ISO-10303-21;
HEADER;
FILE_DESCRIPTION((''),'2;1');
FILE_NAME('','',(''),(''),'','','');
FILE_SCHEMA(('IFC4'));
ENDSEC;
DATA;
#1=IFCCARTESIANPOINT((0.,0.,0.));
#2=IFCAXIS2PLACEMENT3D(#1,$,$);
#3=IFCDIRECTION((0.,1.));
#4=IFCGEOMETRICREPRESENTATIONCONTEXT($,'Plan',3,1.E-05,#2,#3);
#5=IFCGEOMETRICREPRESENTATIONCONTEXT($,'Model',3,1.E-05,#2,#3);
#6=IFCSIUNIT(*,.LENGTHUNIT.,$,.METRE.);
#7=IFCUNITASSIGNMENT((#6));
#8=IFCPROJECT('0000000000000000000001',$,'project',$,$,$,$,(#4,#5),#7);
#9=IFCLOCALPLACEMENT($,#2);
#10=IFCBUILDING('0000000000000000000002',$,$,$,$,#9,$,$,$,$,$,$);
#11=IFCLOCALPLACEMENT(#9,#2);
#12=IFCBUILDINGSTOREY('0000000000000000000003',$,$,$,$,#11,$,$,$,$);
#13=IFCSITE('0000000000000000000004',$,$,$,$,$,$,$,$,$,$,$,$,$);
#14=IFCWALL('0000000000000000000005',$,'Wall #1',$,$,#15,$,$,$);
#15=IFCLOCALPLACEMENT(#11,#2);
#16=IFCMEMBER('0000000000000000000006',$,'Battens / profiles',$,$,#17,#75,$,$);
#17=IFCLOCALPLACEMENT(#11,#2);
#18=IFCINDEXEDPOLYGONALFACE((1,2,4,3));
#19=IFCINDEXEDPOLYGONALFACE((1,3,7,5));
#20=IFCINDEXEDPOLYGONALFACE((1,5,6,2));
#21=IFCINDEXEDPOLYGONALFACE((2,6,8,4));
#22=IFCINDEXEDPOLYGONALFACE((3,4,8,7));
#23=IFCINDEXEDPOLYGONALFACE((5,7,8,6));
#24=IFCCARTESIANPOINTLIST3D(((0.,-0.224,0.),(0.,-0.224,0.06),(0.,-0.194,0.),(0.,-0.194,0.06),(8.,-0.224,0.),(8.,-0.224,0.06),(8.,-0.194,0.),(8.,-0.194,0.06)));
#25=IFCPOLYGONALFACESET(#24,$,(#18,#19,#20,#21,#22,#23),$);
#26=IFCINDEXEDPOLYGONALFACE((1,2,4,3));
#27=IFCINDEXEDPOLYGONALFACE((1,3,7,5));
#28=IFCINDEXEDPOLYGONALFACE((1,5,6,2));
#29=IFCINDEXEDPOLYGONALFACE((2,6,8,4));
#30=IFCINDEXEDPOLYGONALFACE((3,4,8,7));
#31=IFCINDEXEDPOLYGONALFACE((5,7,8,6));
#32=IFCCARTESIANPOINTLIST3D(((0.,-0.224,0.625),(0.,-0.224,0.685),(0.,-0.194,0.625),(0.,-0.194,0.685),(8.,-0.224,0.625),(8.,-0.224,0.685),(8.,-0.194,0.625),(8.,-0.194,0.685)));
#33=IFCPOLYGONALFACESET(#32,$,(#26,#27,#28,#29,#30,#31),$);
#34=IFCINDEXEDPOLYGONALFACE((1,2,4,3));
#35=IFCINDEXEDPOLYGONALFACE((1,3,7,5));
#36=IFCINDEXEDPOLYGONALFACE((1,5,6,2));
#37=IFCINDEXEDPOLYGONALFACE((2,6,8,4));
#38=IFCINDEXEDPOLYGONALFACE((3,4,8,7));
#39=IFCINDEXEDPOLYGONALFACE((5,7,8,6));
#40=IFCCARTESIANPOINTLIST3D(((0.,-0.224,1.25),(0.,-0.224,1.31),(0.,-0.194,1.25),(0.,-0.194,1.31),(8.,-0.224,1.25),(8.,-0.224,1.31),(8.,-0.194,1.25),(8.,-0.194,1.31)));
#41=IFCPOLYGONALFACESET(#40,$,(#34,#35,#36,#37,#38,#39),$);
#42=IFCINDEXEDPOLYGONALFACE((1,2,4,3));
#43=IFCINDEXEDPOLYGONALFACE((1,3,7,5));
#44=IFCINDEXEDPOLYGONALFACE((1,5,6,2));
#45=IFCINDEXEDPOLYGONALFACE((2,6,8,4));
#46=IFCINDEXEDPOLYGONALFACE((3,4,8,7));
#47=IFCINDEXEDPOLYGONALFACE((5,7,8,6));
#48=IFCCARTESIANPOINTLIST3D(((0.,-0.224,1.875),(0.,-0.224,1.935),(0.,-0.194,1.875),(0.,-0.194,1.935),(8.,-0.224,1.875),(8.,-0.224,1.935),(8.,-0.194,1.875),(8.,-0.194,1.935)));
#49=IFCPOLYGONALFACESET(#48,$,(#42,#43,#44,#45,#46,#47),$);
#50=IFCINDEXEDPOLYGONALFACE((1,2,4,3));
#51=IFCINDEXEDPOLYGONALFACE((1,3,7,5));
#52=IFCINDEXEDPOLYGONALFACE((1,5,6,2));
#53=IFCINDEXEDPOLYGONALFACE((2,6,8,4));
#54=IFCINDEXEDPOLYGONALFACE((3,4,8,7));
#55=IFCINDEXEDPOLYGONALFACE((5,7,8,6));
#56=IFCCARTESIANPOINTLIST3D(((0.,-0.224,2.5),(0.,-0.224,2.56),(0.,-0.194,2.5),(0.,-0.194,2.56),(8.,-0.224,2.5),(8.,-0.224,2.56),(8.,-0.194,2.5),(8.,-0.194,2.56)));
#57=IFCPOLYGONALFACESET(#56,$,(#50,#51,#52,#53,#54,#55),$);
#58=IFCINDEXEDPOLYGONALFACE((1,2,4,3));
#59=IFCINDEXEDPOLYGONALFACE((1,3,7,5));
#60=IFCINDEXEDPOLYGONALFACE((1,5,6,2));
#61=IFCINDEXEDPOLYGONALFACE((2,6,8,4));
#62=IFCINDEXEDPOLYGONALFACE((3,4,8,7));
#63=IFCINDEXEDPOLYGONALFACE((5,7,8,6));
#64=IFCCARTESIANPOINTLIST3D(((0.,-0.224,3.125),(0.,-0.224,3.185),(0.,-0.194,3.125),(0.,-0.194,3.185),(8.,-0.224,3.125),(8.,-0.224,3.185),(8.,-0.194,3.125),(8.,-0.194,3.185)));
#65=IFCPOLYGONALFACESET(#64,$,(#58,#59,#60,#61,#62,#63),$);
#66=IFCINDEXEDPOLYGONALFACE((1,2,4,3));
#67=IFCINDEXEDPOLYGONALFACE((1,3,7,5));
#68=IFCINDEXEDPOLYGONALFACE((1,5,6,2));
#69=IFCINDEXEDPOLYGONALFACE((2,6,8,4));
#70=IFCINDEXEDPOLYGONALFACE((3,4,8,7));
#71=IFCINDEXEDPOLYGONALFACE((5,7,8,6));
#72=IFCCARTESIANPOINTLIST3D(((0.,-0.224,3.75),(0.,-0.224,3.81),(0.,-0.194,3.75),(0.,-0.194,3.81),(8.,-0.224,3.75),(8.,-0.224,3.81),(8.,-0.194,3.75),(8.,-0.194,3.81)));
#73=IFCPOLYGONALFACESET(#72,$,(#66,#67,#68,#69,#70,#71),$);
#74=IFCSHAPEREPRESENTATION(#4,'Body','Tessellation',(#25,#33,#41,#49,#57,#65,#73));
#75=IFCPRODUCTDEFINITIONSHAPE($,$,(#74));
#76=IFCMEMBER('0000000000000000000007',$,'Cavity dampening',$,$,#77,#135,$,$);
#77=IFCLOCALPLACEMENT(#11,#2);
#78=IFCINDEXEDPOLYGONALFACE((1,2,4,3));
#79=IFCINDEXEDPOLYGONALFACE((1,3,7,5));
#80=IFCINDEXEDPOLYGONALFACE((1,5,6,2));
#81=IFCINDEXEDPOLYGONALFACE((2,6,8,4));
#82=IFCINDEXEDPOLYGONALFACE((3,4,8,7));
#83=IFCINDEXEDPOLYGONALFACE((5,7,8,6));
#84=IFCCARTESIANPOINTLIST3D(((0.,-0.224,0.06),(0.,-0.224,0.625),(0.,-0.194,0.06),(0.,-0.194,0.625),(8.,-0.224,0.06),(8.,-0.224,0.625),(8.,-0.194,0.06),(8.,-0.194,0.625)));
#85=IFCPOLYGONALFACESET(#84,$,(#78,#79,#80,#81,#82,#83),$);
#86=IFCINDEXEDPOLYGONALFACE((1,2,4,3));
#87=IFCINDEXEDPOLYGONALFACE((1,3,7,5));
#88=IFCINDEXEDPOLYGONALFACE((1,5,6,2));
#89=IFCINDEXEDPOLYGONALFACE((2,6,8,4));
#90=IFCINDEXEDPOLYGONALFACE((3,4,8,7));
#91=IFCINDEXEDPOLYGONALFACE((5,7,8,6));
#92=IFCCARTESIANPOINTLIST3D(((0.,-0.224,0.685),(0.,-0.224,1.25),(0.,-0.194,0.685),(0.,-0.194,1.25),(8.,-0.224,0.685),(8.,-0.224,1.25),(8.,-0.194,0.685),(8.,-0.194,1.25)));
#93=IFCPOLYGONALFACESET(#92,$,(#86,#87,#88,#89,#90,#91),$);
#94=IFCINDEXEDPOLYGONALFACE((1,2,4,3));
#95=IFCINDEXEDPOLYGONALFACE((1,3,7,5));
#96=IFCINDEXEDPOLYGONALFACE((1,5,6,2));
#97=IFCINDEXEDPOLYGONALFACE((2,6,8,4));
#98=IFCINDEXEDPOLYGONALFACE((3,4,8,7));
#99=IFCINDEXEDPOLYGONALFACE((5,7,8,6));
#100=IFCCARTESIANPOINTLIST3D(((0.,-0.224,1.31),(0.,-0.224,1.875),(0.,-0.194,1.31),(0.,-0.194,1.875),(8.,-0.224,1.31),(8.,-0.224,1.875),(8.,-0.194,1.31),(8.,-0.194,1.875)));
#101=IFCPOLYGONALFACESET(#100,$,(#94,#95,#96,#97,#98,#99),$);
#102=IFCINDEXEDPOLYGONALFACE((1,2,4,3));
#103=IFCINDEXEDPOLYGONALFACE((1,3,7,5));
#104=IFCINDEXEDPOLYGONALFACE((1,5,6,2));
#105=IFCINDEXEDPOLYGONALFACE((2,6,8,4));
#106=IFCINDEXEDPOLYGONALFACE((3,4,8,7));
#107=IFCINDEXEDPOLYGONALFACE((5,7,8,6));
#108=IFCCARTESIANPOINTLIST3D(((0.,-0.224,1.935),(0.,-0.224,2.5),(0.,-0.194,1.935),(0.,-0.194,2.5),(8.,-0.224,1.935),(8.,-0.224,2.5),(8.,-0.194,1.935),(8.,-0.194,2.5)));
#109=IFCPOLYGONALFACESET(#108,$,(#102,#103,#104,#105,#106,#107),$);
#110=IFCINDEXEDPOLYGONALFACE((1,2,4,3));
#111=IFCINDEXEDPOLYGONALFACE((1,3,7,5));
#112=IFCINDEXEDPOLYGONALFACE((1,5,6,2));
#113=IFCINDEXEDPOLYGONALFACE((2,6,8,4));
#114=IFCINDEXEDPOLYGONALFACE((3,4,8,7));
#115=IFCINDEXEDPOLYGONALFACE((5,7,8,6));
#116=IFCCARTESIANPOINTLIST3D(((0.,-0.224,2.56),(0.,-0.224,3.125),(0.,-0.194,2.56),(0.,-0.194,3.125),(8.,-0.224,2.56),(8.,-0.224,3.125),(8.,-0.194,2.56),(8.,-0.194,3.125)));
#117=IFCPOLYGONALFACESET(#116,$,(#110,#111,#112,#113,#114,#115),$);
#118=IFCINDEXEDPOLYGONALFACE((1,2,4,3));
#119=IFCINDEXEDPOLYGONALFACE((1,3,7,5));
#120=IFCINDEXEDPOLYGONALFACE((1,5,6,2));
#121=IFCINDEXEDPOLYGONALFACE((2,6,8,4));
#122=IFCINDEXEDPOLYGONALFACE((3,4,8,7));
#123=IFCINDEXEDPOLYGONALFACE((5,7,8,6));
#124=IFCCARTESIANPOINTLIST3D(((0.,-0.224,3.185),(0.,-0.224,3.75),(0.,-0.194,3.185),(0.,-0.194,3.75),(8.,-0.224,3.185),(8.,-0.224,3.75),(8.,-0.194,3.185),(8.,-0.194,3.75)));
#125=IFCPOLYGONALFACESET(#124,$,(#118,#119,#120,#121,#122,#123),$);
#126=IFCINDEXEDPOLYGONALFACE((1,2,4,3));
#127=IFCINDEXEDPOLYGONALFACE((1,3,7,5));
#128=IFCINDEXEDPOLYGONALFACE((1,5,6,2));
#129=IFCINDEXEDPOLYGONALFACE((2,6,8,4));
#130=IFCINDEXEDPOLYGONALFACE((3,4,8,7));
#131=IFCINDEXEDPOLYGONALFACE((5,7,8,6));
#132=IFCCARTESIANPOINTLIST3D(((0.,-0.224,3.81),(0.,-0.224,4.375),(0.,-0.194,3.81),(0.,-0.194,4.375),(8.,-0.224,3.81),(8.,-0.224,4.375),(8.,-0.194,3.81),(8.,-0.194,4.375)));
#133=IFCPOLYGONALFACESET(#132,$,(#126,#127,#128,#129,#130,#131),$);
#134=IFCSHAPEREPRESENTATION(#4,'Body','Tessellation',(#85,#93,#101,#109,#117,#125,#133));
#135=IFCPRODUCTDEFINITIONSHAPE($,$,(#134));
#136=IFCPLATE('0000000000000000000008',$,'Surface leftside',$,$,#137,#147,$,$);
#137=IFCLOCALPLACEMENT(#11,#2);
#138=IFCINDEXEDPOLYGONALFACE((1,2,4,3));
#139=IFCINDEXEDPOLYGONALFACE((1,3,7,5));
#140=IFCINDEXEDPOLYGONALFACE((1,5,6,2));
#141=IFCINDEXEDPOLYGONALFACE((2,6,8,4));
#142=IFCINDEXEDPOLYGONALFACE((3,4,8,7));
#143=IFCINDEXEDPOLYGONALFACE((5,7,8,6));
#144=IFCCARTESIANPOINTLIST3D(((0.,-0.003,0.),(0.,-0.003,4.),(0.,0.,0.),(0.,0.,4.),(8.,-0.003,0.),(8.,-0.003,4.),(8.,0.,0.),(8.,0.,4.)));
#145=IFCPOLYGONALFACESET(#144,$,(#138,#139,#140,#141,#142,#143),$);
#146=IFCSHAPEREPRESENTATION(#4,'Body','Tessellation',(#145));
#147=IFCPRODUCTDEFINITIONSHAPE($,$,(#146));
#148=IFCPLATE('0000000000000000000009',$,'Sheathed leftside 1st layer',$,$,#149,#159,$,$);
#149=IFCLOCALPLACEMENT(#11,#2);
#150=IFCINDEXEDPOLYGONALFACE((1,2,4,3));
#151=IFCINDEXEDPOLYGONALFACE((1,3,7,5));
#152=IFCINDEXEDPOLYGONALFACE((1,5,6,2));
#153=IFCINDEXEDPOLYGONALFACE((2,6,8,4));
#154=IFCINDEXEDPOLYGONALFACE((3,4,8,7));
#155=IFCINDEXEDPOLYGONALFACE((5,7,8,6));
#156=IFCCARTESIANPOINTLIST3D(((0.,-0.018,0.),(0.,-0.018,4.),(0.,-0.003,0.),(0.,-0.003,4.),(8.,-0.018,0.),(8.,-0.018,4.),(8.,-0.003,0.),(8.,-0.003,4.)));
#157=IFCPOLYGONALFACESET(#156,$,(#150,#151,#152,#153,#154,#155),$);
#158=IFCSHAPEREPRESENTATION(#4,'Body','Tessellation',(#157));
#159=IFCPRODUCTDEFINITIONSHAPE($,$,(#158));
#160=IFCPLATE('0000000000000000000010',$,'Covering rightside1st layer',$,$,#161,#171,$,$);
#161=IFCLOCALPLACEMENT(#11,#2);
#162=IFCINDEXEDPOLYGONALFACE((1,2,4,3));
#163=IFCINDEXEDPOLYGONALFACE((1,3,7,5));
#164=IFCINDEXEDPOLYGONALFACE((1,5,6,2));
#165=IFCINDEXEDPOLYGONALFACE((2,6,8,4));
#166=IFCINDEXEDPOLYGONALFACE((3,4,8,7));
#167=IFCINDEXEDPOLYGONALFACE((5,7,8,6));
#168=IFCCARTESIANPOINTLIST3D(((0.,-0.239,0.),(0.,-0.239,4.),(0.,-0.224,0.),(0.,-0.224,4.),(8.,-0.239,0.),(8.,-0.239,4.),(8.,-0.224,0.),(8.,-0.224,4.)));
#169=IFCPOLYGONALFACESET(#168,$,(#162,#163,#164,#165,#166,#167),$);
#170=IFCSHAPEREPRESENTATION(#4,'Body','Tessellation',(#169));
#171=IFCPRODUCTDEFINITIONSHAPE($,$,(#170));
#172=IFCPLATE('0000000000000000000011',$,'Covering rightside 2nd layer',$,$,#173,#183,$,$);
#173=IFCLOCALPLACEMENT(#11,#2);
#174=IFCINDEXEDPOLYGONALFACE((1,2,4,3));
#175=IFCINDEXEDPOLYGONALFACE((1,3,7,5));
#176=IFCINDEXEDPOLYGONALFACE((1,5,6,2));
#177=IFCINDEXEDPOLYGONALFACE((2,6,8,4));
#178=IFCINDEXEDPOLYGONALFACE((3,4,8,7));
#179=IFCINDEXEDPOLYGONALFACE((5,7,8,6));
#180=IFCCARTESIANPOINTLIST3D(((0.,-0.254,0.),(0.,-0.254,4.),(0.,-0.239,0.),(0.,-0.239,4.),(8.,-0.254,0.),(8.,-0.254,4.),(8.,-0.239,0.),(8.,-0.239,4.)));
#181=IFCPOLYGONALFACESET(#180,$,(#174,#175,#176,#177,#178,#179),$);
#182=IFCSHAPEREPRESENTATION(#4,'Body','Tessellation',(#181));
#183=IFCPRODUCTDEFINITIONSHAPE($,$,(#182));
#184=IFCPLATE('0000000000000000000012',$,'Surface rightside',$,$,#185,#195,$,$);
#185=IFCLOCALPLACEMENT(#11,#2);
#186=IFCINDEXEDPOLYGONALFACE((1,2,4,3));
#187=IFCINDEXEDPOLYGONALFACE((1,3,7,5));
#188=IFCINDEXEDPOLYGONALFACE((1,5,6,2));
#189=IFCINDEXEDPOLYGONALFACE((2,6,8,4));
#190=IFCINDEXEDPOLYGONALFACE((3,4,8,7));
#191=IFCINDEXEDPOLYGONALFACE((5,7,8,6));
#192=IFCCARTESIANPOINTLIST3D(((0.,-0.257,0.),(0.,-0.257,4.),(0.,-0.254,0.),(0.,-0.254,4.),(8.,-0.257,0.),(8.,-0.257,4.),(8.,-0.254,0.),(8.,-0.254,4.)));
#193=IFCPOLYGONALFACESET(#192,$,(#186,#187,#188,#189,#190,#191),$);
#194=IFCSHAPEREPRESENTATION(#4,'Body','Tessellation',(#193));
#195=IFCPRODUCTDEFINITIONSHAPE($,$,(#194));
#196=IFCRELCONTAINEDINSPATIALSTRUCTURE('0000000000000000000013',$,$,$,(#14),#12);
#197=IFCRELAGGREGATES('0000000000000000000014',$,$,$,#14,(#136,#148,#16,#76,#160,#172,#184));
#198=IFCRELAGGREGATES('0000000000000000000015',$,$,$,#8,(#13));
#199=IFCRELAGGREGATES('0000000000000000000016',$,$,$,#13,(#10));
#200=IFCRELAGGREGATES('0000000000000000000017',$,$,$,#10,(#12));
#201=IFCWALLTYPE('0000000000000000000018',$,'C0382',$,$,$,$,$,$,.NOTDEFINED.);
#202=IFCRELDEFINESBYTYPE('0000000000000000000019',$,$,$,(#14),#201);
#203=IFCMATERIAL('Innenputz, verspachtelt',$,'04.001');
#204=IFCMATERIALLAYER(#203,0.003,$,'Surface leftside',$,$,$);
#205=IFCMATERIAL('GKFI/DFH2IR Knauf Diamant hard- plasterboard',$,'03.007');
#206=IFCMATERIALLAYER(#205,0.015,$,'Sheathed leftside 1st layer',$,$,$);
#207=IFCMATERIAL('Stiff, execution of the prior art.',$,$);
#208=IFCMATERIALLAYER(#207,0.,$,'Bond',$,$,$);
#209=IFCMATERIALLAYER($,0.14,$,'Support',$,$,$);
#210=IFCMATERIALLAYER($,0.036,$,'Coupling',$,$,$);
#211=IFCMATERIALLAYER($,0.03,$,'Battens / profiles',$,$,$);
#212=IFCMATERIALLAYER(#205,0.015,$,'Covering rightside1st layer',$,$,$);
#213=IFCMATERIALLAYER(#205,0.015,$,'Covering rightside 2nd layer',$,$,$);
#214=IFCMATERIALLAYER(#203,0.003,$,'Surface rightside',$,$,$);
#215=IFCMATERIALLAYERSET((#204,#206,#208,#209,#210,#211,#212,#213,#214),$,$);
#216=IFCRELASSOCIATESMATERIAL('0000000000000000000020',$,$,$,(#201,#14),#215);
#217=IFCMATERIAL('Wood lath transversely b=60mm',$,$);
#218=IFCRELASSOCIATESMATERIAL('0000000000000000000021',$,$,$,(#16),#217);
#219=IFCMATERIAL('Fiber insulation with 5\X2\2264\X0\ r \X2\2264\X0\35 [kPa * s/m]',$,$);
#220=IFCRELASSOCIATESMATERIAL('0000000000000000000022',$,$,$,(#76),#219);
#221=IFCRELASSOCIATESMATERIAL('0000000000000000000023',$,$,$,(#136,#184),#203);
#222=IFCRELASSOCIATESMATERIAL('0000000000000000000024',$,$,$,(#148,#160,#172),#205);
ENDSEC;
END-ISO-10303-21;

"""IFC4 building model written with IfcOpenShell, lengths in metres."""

from ifc_helpers import new_model, si_unit, direction, frame, frame_2d, origin, origin_with_axes, place, context, project, spatial, rectangle, extrude, material, layer, layer_set, type_object, element, aggregate, save


model = new_model("IFC4")

# Units and contexts
plan_context = context("Plan", 3, precision=1e-05, world=origin(), true_north=direction((0.0, 1.0)))
model_context = context("Model", 3, precision=1e-05, world=origin(), true_north=direction((0.0, 1.0)))
ifc_project = project(units=[si_unit("LENGTHUNIT", "METRE")], contexts=[plan_context, model_context])

# Site, building, storey
site = spatial("IfcSite", under=ifc_project)
building_placement = place(None, origin())
building = spatial("IfcBuilding", under=site, at=building_placement)
storey_placement = place(building_placement, origin())
storey = spatial("IfcBuildingStorey", under=building, at=storey_placement)

# Wall, members, plates
ifc_material_1 = material(Name="Innenputz, verspachtelt", Category="04.001")
ifc_layer_1 = layer(ifc_material_1, 0.003, Name="Surface leftside")
ifc_material_2 = material(Name="GKFI/DFH2IR Knauf Diamant hard- plasterboard", Category="03.007")
ifc_layer_2 = layer(ifc_material_2, 0.015, Name="Sheathed leftside 1st layer")
ifc_material_3 = material(Name="Stiff, execution of the prior art.")
ifc_layer_3 = layer(ifc_material_3, 0.0, Name="Bond")
ifc_layer_4 = layer(None, 0.14, Name="Support")
ifc_layer_5 = layer(None, 0.036, Name="Coupling")
ifc_layer_6 = layer(None, 0.03, Name="Battens / profiles")
ifc_layer_7 = layer(ifc_material_2, 0.015, Name="Covering rightside1st layer")
ifc_layer_8 = layer(ifc_material_2, 0.015, Name="Covering rightside 2nd layer")
ifc_layer_9 = layer(ifc_material_1, 0.003, Name="Surface rightside")
ifc_layer_set = layer_set([ifc_layer_1, ifc_layer_2, ifc_layer_3, ifc_layer_4, ifc_layer_5, ifc_layer_6, ifc_layer_7, ifc_layer_8, ifc_layer_9])
wall_type = type_object("IfcWallType", Name="C0382", PredefinedType="NOTDEFINED", material=ifc_layer_set)
wall_placement = place(None, frame((0.0, 0.0, 0.0), z_axis=(0.0, -1.0, 0.0), x_axis=(1.0, 0.0, 0.0)))
wall = element("IfcWall", 1, at=wall_placement, inside=storey, type_object=wall_type, material=ifc_layer_set, Name="Wall #1")
ifc_material_4 = material(Name="Wood lath transversely b=60mm")
member_1_placement = place(wall_placement, origin())
member_1 = element("IfcMember", 2, at=member_1_placement, material=ifc_material_4, Name="Battens / profiles", context=plan_context, shape_type="SweptSolid", body=[
    extrude(rectangle(XDim=0.06, YDim=0.03, at=frame_2d((0.03, 0.015), x_axis=(1.0, 0.0))), frame((0.0, 0.0, 0.194), z_axis=(1.0, 0.0, 0.0), x_axis=(0.0, 1.0, 0.0)), (0.0, 0.0, 1.0), 8.0),
    extrude(rectangle(XDim=0.06, YDim=0.03, at=frame_2d((0.03, 0.015), x_axis=(1.0, 0.0))), frame((0.0, 0.625, 0.194), z_axis=(1.0, 0.0, 0.0), x_axis=(0.0, 1.0, 0.0)), (0.0, 0.0, 1.0), 8.0),
    extrude(rectangle(XDim=0.06, YDim=0.03, at=frame_2d((0.03, 0.015), x_axis=(1.0, 0.0))), frame((0.0, 1.25, 0.194), z_axis=(1.0, 0.0, 0.0), x_axis=(0.0, 1.0, 0.0)), (0.0, 0.0, 1.0), 8.0),
    extrude(rectangle(XDim=0.06, YDim=0.03, at=frame_2d((0.03, 0.015), x_axis=(1.0, 0.0))), frame((0.0, 1.875, 0.194), z_axis=(1.0, 0.0, 0.0), x_axis=(0.0, 1.0, 0.0)), (0.0, 0.0, 1.0), 8.0),
    extrude(rectangle(XDim=0.06, YDim=0.03, at=frame_2d((0.03, 0.015), x_axis=(1.0, 0.0))), frame((0.0, 2.5, 0.194), z_axis=(1.0, 0.0, 0.0), x_axis=(0.0, 1.0, 0.0)), (0.0, 0.0, 1.0), 8.0),
    extrude(rectangle(XDim=0.06, YDim=0.03, at=frame_2d((0.03, 0.015), x_axis=(1.0, 0.0))), frame((0.0, 3.125, 0.194), z_axis=(1.0, 0.0, 0.0), x_axis=(0.0, 1.0, 0.0)), (0.0, 0.0, 1.0), 8.0),
    extrude(rectangle(XDim=0.06, YDim=0.03, at=frame_2d((0.03, 0.015), x_axis=(1.0, 0.0))), frame((0.0, 3.75, 0.194), z_axis=(1.0, 0.0, 0.0), x_axis=(0.0, 1.0, 0.0)), (0.0, 0.0, 1.0), 8.0),
])
ifc_material_5 = material(Name="Fiber insulation with 5≤ r ≤35 [kPa * s/m]")
member_2_placement = place(wall_placement, origin())
member_2 = element("IfcMember", 3, at=member_2_placement, material=ifc_material_5, Name="Cavity dampening", context=plan_context, shape_type="SweptSolid", body=[
    extrude(rectangle(XDim=0.565, YDim=0.03, at=frame_2d((0.2825, 0.015), x_axis=(1.0, 0.0))), frame((0.0, 0.06, 0.194), z_axis=(1.0, 0.0, 0.0), x_axis=(0.0, 1.0, 0.0)), (0.0, 0.0, 1.0), 8.0),
    extrude(rectangle(XDim=0.565, YDim=0.03, at=frame_2d((0.2825, 0.015), x_axis=(1.0, 0.0))), frame((0.0, 0.685, 0.194), z_axis=(1.0, 0.0, 0.0), x_axis=(0.0, 1.0, 0.0)), (0.0, 0.0, 1.0), 8.0),
    extrude(rectangle(XDim=0.565, YDim=0.03, at=frame_2d((0.2825, 0.015), x_axis=(1.0, 0.0))), frame((0.0, 1.31, 0.194), z_axis=(1.0, 0.0, 0.0), x_axis=(0.0, 1.0, 0.0)), (0.0, 0.0, 1.0), 8.0),
    extrude(rectangle(XDim=0.565, YDim=0.03, at=frame_2d((0.2825, 0.015), x_axis=(1.0, 0.0))), frame((0.0, 1.935, 0.194), z_axis=(1.0, 0.0, 0.0), x_axis=(0.0, 1.0, 0.0)), (0.0, 0.0, 1.0), 8.0),
    extrude(rectangle(XDim=0.565, YDim=0.03, at=frame_2d((0.2825, 0.015), x_axis=(1.0, 0.0))), frame((0.0, 2.56, 0.194), z_axis=(1.0, 0.0, 0.0), x_axis=(0.0, 1.0, 0.0)), (0.0, 0.0, 1.0), 8.0),
    extrude(rectangle(XDim=0.565, YDim=0.03, at=frame_2d((0.2825, 0.015), x_axis=(1.0, 0.0))), frame((0.0, 3.185, 0.194), z_axis=(1.0, 0.0, 0.0), x_axis=(0.0, 1.0, 0.0)), (0.0, 0.0, 1.0), 8.0),
    extrude(rectangle(XDim=0.565, YDim=0.03, at=frame_2d((0.2825, 0.015), x_axis=(1.0, 0.0))), frame((0.0, 3.81, 0.194), z_axis=(1.0, 0.0, 0.0), x_axis=(0.0, 1.0, 0.0)), (0.0, 0.0, 1.0), 8.0),
])
plate_1_placement = place(wall_placement, origin())
plate_1 = element("IfcPlate", 4, at=plate_1_placement, material=ifc_material_1, Name="Surface leftside", context=plan_context, shape_type="SweptSolid", body=[
    extrude(rectangle(XDim=8.0, YDim=4.0, at=frame_2d((4.0, 2.0), x_axis=(1.0, 0.0))), origin_with_axes(), (0.0, 0.0, 1.0), 0.003),
])
plate_2_placement = place(wall_placement, origin())
plate_2 = element("IfcPlate", 5, at=plate_2_placement, material=ifc_material_2, Name="Sheathed leftside 1st layer", context=plan_context, shape_type="SweptSolid", body=[
    extrude(rectangle(XDim=8.0, YDim=4.0, at=frame_2d((4.0, 2.0), x_axis=(1.0, 0.0))), frame((0.0, 0.0, 0.003), z_axis=(0.0, 0.0, 1.0), x_axis=(1.0, 0.0, 0.0)), (0.0, 0.0, 1.0), 0.015),
])
plate_3_placement = place(wall_placement, origin())
plate_3 = element("IfcPlate", 6, at=plate_3_placement, material=ifc_material_2, Name="Covering rightside1st layer", context=plan_context, shape_type="SweptSolid", body=[
    extrude(rectangle(XDim=8.0, YDim=4.0, at=frame_2d((4.0, 2.0), x_axis=(1.0, 0.0))), frame((0.0, 0.0, 0.224), z_axis=(0.0, 0.0, 1.0), x_axis=(1.0, 0.0, 0.0)), (0.0, 0.0, 1.0), 0.015),
])
plate_4_placement = place(wall_placement, origin())
plate_4 = element("IfcPlate", 7, at=plate_4_placement, material=ifc_material_2, Name="Covering rightside 2nd layer", context=plan_context, shape_type="SweptSolid", body=[
    extrude(rectangle(XDim=8.0, YDim=4.0, at=frame_2d((4.0, 2.0), x_axis=(1.0, 0.0))), frame((0.0, 0.0, 0.239), z_axis=(0.0, 0.0, 1.0), x_axis=(1.0, 0.0, 0.0)), (0.0, 0.0, 1.0), 0.015),
])
plate_5_placement = place(wall_placement, origin())
plate_5 = element("IfcPlate", 8, at=plate_5_placement, material=ifc_material_1, Name="Surface rightside", context=plan_context, shape_type="SweptSolid", body=[
    extrude(rectangle(XDim=8.0, YDim=4.0, at=frame_2d((4.0, 2.0), x_axis=(1.0, 0.0))), frame((0.0, 0.0, 0.254), z_axis=(0.0, 0.0, 1.0), x_axis=(1.0, 0.0, 0.0)), (0.0, 0.0, 1.0), 0.003),
])
aggregate(wall, [plate_1, plate_2, member_1, member_2, plate_3, plate_4, plate_5])

save(model, "model.ifc")
